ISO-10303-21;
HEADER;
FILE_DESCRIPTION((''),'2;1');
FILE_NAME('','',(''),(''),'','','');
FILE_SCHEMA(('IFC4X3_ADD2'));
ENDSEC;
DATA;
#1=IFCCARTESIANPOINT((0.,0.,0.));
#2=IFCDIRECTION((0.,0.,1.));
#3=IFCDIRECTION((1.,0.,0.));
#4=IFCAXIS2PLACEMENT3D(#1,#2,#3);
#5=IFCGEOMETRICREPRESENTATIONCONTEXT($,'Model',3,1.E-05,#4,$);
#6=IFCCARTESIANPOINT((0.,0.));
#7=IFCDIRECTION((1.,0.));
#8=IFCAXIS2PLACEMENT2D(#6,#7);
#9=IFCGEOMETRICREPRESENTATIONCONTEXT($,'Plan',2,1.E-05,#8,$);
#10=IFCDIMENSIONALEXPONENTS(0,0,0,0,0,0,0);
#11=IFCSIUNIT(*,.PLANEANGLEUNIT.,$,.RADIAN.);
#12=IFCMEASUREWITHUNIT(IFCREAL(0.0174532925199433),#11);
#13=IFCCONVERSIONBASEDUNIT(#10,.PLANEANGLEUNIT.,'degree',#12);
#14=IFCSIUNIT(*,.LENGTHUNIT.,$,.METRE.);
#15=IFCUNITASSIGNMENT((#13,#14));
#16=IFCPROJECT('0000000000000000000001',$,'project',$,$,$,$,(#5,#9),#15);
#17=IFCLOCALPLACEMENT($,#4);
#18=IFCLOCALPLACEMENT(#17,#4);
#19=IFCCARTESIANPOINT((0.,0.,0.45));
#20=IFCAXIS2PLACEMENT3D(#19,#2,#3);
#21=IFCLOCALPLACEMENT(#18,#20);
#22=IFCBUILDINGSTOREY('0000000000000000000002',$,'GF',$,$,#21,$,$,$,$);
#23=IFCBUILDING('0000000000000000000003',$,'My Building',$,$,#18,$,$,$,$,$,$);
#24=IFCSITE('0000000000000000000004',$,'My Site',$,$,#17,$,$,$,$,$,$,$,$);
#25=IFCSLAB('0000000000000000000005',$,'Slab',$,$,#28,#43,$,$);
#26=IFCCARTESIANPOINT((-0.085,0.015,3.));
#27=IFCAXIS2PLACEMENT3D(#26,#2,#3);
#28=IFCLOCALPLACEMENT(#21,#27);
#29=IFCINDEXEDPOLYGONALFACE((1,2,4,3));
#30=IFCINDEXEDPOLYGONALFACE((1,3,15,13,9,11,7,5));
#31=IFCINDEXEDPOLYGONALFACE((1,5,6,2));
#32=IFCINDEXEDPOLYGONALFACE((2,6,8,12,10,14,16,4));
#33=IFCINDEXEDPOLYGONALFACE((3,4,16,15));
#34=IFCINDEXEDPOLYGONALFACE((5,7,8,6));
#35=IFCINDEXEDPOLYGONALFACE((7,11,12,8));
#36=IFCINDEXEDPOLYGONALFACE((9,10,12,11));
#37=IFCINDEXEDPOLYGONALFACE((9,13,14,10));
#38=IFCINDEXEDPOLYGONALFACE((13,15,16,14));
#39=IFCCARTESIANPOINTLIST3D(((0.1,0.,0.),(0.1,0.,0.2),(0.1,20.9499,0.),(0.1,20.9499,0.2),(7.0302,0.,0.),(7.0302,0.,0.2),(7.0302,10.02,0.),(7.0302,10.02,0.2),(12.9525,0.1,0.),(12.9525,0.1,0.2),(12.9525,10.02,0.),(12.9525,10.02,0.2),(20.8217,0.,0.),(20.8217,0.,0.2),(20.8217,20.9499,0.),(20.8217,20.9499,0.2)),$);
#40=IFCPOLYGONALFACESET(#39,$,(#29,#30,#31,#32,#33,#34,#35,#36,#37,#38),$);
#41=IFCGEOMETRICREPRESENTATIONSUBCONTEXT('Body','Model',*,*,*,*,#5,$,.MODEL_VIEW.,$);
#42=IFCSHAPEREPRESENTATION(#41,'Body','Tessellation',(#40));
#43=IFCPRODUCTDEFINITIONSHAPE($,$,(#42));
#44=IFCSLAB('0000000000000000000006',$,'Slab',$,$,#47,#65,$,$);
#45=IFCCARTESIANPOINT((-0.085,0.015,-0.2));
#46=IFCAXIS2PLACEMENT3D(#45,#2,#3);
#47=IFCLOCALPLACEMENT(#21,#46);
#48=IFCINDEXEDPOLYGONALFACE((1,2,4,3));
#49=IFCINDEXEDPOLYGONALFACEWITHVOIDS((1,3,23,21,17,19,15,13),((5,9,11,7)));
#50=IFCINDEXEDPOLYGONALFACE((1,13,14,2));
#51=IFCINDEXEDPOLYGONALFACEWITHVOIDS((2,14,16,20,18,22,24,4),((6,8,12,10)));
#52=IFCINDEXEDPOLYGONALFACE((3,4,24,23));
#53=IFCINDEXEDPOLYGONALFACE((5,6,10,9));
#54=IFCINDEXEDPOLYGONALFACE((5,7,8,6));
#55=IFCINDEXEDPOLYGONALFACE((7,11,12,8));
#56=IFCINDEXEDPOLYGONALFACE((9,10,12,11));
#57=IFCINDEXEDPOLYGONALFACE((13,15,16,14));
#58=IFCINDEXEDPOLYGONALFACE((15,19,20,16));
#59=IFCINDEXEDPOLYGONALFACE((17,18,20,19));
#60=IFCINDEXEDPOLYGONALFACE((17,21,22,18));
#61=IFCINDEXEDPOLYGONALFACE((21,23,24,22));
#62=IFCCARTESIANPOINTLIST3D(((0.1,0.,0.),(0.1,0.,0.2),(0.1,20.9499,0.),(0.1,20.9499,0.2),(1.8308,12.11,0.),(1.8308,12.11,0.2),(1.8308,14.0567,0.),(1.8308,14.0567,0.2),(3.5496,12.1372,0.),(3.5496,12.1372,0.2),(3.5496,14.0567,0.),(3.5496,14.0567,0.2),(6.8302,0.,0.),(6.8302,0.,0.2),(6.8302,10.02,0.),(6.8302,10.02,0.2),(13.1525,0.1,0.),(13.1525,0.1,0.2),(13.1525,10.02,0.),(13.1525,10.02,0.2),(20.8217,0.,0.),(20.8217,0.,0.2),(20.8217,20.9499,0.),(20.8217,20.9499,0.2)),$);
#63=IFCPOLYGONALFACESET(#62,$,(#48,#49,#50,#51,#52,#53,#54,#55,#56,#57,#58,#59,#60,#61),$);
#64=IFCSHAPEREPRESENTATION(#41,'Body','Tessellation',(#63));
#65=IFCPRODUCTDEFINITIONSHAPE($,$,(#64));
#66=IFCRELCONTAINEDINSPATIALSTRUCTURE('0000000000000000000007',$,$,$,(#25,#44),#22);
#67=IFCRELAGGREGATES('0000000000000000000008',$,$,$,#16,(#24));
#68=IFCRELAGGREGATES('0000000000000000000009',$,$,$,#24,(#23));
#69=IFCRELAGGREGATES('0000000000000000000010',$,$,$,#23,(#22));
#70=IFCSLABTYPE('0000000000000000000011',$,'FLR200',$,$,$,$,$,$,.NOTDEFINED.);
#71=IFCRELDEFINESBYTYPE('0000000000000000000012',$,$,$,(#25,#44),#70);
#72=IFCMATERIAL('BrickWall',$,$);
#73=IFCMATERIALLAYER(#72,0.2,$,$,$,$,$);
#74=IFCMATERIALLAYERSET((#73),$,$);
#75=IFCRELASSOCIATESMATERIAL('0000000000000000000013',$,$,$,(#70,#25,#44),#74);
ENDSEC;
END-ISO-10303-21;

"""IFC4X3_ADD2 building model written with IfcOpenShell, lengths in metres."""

from ifc_helpers import new_model, entity, si_unit, converted_unit, frame, origin_with_axes, origin_2d_with_axis, place, context, subcontext, project, spatial, line, indexed_curve, outline, extrude, material, layer, layer_set, layer_usage, type_object, element, save


model = new_model("IFC4X3_ADD2")

# Units and contexts
model_context = context("Model", 3, precision=1e-05, world=origin_with_axes())
plan_context = context("Plan", 2, precision=1e-05, world=origin_2d_with_axis())
body_context_1 = subcontext(model_context, "Body", "Model", "MODEL_VIEW")
ifc_project = project(units=[converted_unit("PLANEANGLEUNIT", "degree", entity("IfcReal", 0.0174532925199433), si_unit("PLANEANGLEUNIT", "RADIAN"), dimensions=[0, 0, 0, 0, 0, 0, 0]), si_unit("LENGTHUNIT", "METRE")], contexts=[model_context, plan_context])

# Site, building, storey
site_placement = place(None, origin_with_axes())
site = spatial("IfcSite", under=ifc_project, at=site_placement, Name="My Site")
building_placement = place(site_placement, origin_with_axes())
building = spatial("IfcBuilding", under=site, at=building_placement, Name="My Building")
storey_placement = place(building_placement, frame((0.0, 0.0, 0.45), z_axis=(0.0, 0.0, 1.0), x_axis=(1.0, 0.0, 0.0)))
storey = spatial("IfcBuildingStorey", under=building, at=storey_placement, Name="GF")

# Slabs
ifc_material_1 = material(Name="BrickWall")
ifc_layer_1 = layer(ifc_material_1, 0.2)
ifc_layer_set_1 = layer_set([ifc_layer_1])
ifc_layer_usage_1 = layer_usage(ifc_layer_set_1, "AXIS3", "POSITIVE", 0.0)
slab_type = type_object("IfcSlabType", Name="FLR200", PredefinedType="NOTDEFINED", material=ifc_layer_set_1)
slab_1_placement = place(storey_placement, frame((-0.085, 0.015, 3.0), z_axis=(0.0, 0.0, 1.0), x_axis=(1.0, 0.0, 0.0)))
element("IfcSlab", 1, at=slab_1_placement, inside=storey, type_object=slab_type, material=ifc_layer_usage_1, Name="Slab", context=body_context_1, shape_type="SweptSolid", body=[
    extrude(outline(indexed_curve([(7.0302, 10.02), (7.0302, 0.0), (0.1, 0.0), (0.1, 20.9499), (20.8217, 20.9499), (20.8217, 0.0), (12.9525, 0.1), (12.9525, 10.02)], segments=[line(3, 2), line(2, 1), line(1, 8), line(8, 7), line(7, 6), line(6, 5), line(5, 4), line(4, 3)], self_intersect=False)), None, (0.0, 0.0, 1.0), 0.2),
])
ifc_layer_usage_2 = layer_usage(ifc_layer_set_1, "AXIS3", "POSITIVE", 0.0)
slab_2_placement = place(storey_placement, frame((-0.085, 0.015, -0.2), z_axis=(0.0, 0.0, 1.0), x_axis=(1.0, 0.0, 0.0)))
element("IfcSlab", 2, at=slab_2_placement, inside=storey, type_object=slab_type, material=ifc_layer_usage_2, Name="Slab", context=body_context_1, shape_type="SweptSolid", body=[
    extrude(outline(indexed_curve([(6.8302, 0.0), (0.1, 0.0), (0.1, 20.9499), (20.8217, 20.9499), (20.8217, 0.0), (13.1525, 0.1), (13.1525, 10.02), (6.8302, 10.02), (1.8308, 12.11), (3.5496, 12.1372), (3.5496, 14.0567), (1.8308, 14.0567)], segments=[line(8, 7), line(7, 6), line(6, 5), line(5, 4), line(4, 3), line(3, 2), line(2, 1), line(1, 8)], self_intersect=False), holes=[indexed_curve([(6.8302, 0.0), (0.1, 0.0), (0.1, 20.9499), (20.8217, 20.9499), (20.8217, 0.0), (13.1525, 0.1), (13.1525, 10.02), (6.8302, 10.02), (1.8308, 12.11), (3.5496, 12.1372), (3.5496, 14.0567), (1.8308, 14.0567)], segments=[line(10, 9), line(9, 12), line(12, 11), line(11, 10)], self_intersect=False)]), None, (0.0, 0.0, 1.0), 0.2),
])

save(model, "model.ifc")
